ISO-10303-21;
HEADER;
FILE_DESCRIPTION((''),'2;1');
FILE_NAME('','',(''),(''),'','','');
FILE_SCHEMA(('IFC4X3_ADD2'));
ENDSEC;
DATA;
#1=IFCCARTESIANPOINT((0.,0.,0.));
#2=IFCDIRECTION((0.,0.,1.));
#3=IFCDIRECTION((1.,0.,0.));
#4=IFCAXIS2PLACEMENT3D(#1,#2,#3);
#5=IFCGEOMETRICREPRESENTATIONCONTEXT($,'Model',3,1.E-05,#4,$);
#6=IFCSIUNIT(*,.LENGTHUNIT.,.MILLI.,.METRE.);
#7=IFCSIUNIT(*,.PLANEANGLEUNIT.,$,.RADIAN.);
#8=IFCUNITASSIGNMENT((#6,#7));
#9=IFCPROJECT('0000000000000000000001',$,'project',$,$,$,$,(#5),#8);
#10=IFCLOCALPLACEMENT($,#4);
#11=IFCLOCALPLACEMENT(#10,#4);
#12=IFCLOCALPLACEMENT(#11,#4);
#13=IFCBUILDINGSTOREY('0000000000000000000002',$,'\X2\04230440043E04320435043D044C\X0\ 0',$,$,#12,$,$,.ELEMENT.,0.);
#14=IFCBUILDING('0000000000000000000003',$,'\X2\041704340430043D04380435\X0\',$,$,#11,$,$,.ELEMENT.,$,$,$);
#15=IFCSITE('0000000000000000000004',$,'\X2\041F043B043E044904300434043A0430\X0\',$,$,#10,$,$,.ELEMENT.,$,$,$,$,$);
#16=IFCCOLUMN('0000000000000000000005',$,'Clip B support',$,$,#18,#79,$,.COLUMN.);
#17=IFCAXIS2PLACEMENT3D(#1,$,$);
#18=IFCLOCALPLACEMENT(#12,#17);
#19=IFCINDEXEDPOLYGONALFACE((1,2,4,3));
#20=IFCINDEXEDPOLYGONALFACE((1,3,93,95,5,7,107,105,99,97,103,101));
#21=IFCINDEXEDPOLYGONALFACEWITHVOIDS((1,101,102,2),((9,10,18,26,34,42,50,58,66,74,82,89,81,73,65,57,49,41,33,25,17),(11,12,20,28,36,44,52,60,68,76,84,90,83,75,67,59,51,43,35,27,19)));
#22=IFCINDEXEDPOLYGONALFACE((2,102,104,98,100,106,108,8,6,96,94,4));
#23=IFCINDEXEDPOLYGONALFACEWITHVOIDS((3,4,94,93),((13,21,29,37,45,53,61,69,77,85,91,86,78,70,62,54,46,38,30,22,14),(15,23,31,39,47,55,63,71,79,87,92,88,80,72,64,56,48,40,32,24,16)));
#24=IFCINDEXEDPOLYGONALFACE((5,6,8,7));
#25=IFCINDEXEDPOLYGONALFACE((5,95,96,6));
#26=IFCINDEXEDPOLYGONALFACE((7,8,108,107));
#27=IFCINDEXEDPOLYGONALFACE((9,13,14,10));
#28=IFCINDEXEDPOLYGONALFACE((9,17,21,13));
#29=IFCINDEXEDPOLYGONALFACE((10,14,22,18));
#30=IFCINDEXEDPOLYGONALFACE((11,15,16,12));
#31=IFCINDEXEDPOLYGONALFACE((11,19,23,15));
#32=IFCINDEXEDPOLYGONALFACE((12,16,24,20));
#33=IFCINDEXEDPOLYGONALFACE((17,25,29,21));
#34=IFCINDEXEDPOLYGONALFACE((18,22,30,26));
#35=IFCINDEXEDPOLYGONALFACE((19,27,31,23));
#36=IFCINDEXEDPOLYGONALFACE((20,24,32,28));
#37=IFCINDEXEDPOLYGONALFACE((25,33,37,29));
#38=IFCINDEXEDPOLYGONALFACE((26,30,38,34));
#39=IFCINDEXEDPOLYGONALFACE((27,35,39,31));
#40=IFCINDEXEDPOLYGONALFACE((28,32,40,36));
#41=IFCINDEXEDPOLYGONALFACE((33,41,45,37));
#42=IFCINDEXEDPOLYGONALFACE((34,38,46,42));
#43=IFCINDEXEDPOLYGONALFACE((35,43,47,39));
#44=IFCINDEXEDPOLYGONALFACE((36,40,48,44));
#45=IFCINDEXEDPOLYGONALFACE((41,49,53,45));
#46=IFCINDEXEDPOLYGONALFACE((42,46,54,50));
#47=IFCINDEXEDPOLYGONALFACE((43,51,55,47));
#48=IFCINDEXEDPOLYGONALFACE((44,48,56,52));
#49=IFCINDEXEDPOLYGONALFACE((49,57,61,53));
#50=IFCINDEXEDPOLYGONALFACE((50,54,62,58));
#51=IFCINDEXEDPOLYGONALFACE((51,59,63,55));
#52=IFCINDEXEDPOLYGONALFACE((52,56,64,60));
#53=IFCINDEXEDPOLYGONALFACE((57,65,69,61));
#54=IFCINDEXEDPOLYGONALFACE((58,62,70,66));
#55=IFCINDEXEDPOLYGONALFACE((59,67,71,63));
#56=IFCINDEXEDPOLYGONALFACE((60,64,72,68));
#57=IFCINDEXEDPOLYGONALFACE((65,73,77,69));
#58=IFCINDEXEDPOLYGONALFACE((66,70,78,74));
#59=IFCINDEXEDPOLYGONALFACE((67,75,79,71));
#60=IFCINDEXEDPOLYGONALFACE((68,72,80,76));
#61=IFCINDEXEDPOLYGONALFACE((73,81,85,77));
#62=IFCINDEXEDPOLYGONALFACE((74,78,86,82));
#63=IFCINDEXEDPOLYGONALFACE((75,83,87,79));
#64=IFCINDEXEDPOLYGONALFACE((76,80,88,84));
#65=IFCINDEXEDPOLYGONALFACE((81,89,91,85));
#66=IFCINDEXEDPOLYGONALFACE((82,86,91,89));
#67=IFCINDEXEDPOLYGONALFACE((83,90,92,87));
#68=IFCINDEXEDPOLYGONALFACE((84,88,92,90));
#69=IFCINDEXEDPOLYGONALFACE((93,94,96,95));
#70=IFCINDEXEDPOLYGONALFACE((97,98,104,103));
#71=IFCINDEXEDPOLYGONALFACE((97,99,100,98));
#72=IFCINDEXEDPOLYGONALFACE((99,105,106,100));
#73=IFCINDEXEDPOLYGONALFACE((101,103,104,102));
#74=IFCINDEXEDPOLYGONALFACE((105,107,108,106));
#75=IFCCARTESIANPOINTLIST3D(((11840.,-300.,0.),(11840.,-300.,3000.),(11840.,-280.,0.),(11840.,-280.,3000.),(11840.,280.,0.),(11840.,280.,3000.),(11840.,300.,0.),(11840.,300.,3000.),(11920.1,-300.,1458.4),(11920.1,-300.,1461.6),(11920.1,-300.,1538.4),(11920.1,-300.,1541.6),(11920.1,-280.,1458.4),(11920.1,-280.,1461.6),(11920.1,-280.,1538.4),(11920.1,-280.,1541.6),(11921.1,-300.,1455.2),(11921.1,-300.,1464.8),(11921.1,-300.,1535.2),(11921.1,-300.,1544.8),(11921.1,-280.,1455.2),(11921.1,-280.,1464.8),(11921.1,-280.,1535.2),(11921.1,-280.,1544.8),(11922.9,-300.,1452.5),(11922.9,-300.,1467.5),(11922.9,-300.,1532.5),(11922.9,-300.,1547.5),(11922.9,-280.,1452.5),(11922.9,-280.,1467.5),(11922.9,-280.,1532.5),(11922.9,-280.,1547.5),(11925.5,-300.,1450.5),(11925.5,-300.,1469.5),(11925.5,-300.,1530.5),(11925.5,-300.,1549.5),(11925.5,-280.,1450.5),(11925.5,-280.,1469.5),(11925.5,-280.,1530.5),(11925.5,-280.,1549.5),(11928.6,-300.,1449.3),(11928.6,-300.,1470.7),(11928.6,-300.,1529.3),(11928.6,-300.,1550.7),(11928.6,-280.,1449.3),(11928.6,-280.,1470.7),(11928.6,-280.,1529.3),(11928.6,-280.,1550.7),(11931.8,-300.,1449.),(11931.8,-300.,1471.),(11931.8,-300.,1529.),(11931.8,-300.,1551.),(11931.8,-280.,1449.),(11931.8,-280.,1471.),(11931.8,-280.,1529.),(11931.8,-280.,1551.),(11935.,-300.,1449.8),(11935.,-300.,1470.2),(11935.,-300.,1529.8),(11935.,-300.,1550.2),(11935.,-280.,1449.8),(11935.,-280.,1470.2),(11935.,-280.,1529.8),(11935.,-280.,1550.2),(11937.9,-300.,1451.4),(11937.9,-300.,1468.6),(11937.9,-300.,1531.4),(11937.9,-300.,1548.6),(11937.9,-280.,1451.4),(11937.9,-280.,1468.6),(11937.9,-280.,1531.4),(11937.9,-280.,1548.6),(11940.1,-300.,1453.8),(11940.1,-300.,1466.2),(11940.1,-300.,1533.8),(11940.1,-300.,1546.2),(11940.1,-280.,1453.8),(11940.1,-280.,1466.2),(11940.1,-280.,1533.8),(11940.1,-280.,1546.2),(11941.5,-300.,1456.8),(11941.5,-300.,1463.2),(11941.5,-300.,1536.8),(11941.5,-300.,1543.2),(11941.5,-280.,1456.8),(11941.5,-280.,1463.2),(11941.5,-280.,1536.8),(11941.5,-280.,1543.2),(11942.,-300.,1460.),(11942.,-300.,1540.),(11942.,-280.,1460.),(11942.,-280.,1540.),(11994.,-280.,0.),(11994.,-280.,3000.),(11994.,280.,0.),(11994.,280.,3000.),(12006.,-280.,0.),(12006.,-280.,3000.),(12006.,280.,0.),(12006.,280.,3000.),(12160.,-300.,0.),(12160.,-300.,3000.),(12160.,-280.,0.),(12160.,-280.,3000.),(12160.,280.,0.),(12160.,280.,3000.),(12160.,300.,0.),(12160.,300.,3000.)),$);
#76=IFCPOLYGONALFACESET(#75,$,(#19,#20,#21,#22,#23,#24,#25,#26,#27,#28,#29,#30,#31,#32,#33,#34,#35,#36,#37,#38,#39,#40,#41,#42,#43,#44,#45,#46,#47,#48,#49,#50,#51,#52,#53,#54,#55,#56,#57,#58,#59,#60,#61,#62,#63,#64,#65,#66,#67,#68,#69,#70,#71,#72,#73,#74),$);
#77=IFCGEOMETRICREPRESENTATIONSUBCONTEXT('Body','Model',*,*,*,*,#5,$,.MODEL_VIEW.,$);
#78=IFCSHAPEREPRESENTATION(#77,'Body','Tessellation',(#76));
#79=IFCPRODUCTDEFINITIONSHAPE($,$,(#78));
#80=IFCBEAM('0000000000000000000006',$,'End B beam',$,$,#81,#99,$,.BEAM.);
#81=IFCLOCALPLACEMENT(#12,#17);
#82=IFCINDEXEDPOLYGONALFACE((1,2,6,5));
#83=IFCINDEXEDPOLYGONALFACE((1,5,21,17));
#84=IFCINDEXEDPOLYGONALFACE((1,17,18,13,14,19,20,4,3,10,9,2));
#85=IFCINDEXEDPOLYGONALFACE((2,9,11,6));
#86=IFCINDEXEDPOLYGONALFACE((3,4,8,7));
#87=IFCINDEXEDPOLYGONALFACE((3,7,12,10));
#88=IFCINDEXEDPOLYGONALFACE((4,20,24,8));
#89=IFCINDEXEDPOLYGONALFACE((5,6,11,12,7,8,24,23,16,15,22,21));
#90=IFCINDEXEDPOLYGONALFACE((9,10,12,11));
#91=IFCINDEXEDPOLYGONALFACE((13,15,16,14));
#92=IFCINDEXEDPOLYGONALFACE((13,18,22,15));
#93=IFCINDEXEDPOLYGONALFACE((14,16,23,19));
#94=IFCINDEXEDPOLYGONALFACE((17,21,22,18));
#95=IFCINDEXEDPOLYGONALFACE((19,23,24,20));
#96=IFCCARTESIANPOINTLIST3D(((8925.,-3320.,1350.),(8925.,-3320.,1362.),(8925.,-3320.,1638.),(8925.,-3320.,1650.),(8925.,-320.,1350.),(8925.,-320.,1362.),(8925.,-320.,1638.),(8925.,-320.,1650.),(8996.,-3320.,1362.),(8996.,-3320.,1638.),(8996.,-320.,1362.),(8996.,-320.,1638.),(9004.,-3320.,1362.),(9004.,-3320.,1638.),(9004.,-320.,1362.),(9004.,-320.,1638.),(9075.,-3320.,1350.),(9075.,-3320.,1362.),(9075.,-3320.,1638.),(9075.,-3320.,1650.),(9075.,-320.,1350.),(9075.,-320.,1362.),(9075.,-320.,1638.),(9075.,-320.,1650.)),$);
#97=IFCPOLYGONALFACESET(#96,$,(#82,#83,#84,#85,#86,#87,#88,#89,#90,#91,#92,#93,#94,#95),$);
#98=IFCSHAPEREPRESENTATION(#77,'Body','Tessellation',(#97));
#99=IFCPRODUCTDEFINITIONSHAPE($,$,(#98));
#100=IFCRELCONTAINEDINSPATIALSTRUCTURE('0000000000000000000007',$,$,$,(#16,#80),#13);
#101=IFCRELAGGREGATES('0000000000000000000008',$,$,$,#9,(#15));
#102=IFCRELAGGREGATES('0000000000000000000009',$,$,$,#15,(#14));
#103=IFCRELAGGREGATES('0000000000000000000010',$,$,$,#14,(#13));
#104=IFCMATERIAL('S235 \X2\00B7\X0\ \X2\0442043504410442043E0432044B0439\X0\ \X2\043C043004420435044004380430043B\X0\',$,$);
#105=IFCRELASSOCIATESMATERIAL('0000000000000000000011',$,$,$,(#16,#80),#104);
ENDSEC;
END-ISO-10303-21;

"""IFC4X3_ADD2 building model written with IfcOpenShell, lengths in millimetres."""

from ifc_helpers import new_model, si_unit, frame, origin_with_axes, place, context, subcontext, project, spatial, circle, i_section, extrude, material, element, save


model = new_model("IFC4X3_ADD2")

# Units and contexts
model_context = context("Model", 3, precision=1e-05, world=origin_with_axes())
body_context = subcontext(model_context, "Body", "Model", "MODEL_VIEW")
ifc_project = project(units=[si_unit("LENGTHUNIT", "METRE", prefix="MILLI"), si_unit("PLANEANGLEUNIT", "RADIAN")], contexts=[model_context])

# Site, building, storey
site_placement = place(None, origin_with_axes())
site = spatial("IfcSite", under=ifc_project, at=site_placement, Name="Площадка", CompositionType="ELEMENT")
building_placement = place(site_placement, origin_with_axes())
building = spatial("IfcBuilding", under=site, at=building_placement, Name="Здание", CompositionType="ELEMENT")
storey_placement = place(building_placement, origin_with_axes())
storey = spatial("IfcBuildingStorey", under=building, at=storey_placement, Name="Уровень 0", CompositionType="ELEMENT", Elevation=0.0)

# Column, openings
ifc_material = material(Name="S235 · тестовый материал")
column_1_placement = place(storey_placement, frame((12000.0, 0.0, 0.0), z_axis=(0.0, 0.0, 1.0), x_axis=(1.0, 0.0, 0.0)))
column_1 = element("IfcColumn", 1, at=column_1_placement, inside=storey, material=ifc_material, Name="Clip B support", PredefinedType="COLUMN", context=body_context, shape_type="SweptSolid", body=[
    extrude(i_section(OverallWidth=320.0, OverallDepth=600.0, WebThickness=12.0, FlangeThickness=20.0), origin_with_axes(), (0.0, 0.0, 1.0), 3000.0),
])
opening_1_placement = place(column_1_placement, frame((-69.0, -321.0, 1540.0), z_axis=(0.0, 1.0, 0.0), x_axis=(1.0, 0.0, 0.0)))
element("IfcOpeningElement", 2, at=opening_1_placement, cuts=column_1, PredefinedType="OPENING", context=body_context, shape_type="SweptSolid", body=[
    extrude(circle(Radius=11.0), origin_with_axes(), (0.0, 0.0, 1.0), 42.0),
])
opening_2_placement = place(column_1_placement, frame((-69.0, -321.0, 1460.0), z_axis=(0.0, 1.0, 0.0), x_axis=(1.0, 0.0, 0.0)))
element("IfcOpeningElement", 3, at=opening_2_placement, cuts=column_1, PredefinedType="OPENING", context=body_context, shape_type="SweptSolid", body=[
    extrude(circle(Radius=11.0), origin_with_axes(), (0.0, 0.0, 1.0), 42.0),
])

# Beam
beam_1_placement = place(storey_placement, frame((9000.0, -3320.0, 1500.0), z_axis=(0.0, 1.0, 0.0), x_axis=(-1.0, 0.0, 0.0)))
element("IfcBeam", 4, at=beam_1_placement, inside=storey, material=ifc_material, Name="End B beam", PredefinedType="BEAM", context=body_context, shape_type="SweptSolid", body=[
    extrude(i_section(OverallWidth=150.0, OverallDepth=300.0, WebThickness=8.0, FlangeThickness=12.0), origin_with_axes(), (0.0, 0.0, 1.0), 3000.0),
])

save(model, "model.ifc")
